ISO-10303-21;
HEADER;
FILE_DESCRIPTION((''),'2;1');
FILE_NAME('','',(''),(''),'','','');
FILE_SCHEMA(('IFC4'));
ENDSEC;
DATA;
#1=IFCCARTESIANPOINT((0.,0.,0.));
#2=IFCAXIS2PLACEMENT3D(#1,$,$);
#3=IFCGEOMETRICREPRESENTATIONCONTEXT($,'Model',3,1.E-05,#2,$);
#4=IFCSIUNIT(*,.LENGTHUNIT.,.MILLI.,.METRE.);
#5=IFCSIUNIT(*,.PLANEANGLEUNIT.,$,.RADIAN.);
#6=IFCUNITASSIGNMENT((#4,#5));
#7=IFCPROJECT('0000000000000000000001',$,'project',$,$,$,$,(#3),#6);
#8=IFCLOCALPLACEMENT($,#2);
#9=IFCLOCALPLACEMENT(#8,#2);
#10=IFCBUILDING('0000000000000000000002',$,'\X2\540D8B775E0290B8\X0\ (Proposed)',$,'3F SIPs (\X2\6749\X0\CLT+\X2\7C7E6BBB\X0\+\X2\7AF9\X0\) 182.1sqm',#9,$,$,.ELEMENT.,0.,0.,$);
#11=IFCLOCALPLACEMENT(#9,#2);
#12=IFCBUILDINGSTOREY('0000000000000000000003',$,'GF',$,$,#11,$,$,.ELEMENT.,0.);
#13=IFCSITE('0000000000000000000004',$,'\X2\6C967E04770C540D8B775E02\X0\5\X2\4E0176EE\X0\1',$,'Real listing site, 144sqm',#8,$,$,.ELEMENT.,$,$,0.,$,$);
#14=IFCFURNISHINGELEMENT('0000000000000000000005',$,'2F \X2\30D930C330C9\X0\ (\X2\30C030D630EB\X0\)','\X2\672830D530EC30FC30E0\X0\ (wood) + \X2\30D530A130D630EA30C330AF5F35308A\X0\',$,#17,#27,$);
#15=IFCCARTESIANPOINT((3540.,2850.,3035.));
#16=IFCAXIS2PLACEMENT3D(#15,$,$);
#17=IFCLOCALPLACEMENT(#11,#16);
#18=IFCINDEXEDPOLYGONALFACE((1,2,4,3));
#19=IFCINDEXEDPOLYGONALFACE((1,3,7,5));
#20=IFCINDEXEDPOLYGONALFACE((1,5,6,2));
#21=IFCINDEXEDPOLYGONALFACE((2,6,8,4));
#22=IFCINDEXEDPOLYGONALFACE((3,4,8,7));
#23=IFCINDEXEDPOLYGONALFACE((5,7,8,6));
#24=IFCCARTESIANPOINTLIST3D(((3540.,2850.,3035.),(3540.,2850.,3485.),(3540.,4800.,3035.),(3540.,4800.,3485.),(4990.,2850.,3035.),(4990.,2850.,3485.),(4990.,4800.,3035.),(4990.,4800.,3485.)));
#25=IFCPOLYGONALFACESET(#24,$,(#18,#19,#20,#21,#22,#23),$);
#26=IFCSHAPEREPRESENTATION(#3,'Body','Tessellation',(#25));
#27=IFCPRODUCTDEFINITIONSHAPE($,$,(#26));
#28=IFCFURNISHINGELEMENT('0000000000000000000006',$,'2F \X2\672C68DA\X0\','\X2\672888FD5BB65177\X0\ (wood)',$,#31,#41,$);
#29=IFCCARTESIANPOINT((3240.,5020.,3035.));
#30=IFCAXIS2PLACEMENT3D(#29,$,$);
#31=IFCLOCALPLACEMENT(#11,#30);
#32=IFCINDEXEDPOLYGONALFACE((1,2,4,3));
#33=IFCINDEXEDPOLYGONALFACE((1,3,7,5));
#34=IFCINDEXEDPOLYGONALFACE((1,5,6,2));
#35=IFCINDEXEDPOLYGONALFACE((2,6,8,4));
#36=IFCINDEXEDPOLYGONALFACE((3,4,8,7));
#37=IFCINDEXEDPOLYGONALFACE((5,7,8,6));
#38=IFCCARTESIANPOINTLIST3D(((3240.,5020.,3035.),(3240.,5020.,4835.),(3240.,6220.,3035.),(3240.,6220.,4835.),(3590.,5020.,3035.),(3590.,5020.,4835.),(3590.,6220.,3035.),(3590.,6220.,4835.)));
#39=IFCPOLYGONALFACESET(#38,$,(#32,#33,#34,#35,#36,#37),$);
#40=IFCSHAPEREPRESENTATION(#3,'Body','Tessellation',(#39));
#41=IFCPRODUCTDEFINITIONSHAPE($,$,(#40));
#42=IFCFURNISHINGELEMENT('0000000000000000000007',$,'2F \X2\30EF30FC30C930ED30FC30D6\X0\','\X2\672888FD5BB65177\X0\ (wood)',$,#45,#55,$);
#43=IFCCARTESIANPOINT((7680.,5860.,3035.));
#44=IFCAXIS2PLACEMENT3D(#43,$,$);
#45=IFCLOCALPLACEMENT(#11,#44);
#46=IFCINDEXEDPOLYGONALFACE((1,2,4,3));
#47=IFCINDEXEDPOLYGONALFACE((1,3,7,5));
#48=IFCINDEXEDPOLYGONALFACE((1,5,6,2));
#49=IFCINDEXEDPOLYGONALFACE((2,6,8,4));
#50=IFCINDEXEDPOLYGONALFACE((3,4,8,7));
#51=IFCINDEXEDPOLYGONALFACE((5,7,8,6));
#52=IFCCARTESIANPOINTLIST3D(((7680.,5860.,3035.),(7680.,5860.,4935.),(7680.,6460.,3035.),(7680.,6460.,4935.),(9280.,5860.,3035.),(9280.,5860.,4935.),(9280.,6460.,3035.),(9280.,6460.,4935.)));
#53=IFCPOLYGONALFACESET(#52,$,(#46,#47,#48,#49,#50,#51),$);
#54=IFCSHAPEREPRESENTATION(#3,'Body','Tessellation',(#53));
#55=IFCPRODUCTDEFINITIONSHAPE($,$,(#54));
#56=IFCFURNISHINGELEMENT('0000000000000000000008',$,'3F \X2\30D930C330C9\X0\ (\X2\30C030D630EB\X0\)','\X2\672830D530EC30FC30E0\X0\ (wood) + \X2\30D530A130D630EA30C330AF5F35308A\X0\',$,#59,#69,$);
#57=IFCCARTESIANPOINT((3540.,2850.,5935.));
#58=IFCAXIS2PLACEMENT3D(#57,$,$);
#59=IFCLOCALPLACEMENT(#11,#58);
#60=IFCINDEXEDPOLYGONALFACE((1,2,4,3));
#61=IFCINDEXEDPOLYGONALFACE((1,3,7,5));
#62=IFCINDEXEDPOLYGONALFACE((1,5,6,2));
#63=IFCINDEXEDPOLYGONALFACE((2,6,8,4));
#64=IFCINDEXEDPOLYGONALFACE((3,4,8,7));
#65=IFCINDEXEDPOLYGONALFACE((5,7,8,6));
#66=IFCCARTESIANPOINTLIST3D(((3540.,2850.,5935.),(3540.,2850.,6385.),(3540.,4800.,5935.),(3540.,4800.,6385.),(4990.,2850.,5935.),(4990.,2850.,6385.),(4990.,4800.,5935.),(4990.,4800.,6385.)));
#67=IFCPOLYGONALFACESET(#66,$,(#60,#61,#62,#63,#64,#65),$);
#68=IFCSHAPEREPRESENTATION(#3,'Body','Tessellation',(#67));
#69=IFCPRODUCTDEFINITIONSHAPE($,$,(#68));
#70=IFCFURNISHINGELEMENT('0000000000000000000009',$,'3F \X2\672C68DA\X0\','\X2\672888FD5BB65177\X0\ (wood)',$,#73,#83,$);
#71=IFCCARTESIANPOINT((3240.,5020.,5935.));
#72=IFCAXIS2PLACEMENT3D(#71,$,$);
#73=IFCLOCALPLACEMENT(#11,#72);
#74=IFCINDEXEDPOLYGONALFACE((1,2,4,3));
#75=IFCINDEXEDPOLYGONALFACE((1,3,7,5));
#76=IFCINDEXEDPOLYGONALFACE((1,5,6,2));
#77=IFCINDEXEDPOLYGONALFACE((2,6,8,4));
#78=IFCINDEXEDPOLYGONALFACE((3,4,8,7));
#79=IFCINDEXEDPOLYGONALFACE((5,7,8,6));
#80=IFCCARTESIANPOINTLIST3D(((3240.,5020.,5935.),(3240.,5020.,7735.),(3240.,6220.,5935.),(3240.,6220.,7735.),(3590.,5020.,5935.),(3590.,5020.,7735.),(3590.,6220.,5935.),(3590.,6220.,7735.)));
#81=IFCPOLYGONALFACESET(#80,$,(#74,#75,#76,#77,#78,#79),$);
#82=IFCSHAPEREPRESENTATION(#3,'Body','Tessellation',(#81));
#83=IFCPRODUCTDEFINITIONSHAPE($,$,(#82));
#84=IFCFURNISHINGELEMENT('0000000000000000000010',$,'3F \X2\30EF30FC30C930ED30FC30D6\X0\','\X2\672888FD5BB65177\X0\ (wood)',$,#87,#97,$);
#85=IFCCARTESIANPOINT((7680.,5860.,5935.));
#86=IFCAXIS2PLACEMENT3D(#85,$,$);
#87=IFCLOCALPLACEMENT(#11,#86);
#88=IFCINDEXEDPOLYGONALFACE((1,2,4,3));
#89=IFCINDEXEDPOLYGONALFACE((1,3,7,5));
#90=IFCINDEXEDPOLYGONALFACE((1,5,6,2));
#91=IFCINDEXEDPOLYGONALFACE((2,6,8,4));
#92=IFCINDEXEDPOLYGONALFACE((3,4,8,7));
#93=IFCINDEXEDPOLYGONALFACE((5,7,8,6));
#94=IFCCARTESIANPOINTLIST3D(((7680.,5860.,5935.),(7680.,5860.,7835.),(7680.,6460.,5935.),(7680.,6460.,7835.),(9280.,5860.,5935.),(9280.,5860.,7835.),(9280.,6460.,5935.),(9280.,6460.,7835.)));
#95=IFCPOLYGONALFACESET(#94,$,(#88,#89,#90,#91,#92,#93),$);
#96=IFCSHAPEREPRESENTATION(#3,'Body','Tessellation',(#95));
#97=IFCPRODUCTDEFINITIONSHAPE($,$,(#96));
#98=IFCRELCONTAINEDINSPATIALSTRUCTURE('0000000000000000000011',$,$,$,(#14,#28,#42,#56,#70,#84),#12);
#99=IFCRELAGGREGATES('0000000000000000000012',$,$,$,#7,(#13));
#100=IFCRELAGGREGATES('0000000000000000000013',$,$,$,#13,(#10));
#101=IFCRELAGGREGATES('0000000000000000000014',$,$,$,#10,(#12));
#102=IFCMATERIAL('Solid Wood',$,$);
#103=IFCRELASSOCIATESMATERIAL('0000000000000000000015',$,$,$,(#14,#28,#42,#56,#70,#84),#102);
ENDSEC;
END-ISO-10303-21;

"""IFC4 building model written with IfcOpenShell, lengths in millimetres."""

from ifc_helpers import new_model, si_unit, frame, frame_2d, origin, place, context, project, spatial, rectangle, extrude, material, element, save


model = new_model("IFC4")

# Units and contexts
model_context = context("Model", 3, precision=1e-05, world=origin())
ifc_project = project(units=[si_unit("LENGTHUNIT", "METRE", prefix="MILLI"), si_unit("PLANEANGLEUNIT", "RADIAN")], contexts=[model_context])

# Site, building, storey
site_placement = place(None, origin())
site = spatial("IfcSite", under=ifc_project, at=site_placement, Name="沖縄県名護市5丁目1", ObjectType="Real listing site, 144sqm", CompositionType="ELEMENT", RefElevation=0.0)
building_placement = place(site_placement, origin())
building = spatial("IfcBuilding", under=site, at=building_placement, Name="名護市邸 (Proposed)", ObjectType="3F SIPs (杉CLT+籾殻+竹) 182.1sqm", CompositionType="ELEMENT", ElevationOfRefHeight=0.0, ElevationOfTerrain=0.0)
storey_placement = place(building_placement, origin())
storey = spatial("IfcBuildingStorey", under=building, at=storey_placement, Name="GF", CompositionType="ELEMENT", Elevation=0.0)

# Shared definitions
ifc_material_1 = material(Name="Solid Wood")

# Furnishing elements
furnishing_1_placement = place(storey_placement, frame((3540.0, 2850.0, 3035.0)))
element("IfcFurnishingElement", 1, at=furnishing_1_placement, inside=storey, material=ifc_material_1, Name="2F ベッド (ダブル)", Description="木フレーム (wood) + ファブリック張り", context=model_context, shape_type="SweptSolid", body=[
    extrude(rectangle(XDim=1450.0, YDim=1950.0, at=frame_2d((725.0, 975.0))), frame((3540.0, 2850.0, 3035.0)), (0.0, 0.0, 1.0), 450.0),
])
furnishing_2_placement = place(storey_placement, frame((3240.0, 5020.0, 3035.0)))
element("IfcFurnishingElement", 2, at=furnishing_2_placement, inside=storey, material=ifc_material_1, Name="2F 本棚", Description="木製家具 (wood)", context=model_context, shape_type="SweptSolid", body=[
    extrude(rectangle(XDim=350.0, YDim=1200.0, at=frame_2d((175.0, 600.0))), frame((3240.0, 5020.0, 3035.0)), (0.0, 0.0, 1.0), 1800.0),
])
furnishing_3_placement = place(storey_placement, frame((7680.0, 5860.0, 3035.0)))
element("IfcFurnishingElement", 3, at=furnishing_3_placement, inside=storey, material=ifc_material_1, Name="2F ワードローブ", Description="木製家具 (wood)", context=model_context, shape_type="SweptSolid", body=[
    extrude(rectangle(XDim=1600.0, YDim=600.0, at=frame_2d((800.0, 300.0))), frame((7680.0, 5860.0, 3035.0)), (0.0, 0.0, 1.0), 1900.0),
])
furnishing_4_placement = place(storey_placement, frame((3540.0, 2850.0, 5935.0)))
element("IfcFurnishingElement", 4, at=furnishing_4_placement, inside=storey, material=ifc_material_1, Name="3F ベッド (ダブル)", Description="木フレーム (wood) + ファブリック張り", context=model_context, shape_type="SweptSolid", body=[
    extrude(rectangle(XDim=1450.0, YDim=1950.0, at=frame_2d((725.0, 975.0))), frame((3540.0, 2850.0, 5935.0)), (0.0, 0.0, 1.0), 450.0),
])
furnishing_5_placement = place(storey_placement, frame((3240.0, 5020.0, 5935.0)))
element("IfcFurnishingElement", 5, at=furnishing_5_placement, inside=storey, material=ifc_material_1, Name="3F 本棚", Description="木製家具 (wood)", context=model_context, shape_type="SweptSolid", body=[
    extrude(rectangle(XDim=350.0, YDim=1200.0, at=frame_2d((175.0, 600.0))), frame((3240.0, 5020.0, 5935.0)), (0.0, 0.0, 1.0), 1800.0),
])
furnishing_6_placement = place(storey_placement, frame((7680.0, 5860.0, 5935.0)))
element("IfcFurnishingElement", 6, at=furnishing_6_placement, inside=storey, material=ifc_material_1, Name="3F ワードローブ", Description="木製家具 (wood)", context=model_context, shape_type="SweptSolid", body=[
    extrude(rectangle(XDim=1600.0, YDim=600.0, at=frame_2d((800.0, 300.0))), frame((7680.0, 5860.0, 5935.0)), (0.0, 0.0, 1.0), 1900.0),
])

save(model, "model.ifc")
